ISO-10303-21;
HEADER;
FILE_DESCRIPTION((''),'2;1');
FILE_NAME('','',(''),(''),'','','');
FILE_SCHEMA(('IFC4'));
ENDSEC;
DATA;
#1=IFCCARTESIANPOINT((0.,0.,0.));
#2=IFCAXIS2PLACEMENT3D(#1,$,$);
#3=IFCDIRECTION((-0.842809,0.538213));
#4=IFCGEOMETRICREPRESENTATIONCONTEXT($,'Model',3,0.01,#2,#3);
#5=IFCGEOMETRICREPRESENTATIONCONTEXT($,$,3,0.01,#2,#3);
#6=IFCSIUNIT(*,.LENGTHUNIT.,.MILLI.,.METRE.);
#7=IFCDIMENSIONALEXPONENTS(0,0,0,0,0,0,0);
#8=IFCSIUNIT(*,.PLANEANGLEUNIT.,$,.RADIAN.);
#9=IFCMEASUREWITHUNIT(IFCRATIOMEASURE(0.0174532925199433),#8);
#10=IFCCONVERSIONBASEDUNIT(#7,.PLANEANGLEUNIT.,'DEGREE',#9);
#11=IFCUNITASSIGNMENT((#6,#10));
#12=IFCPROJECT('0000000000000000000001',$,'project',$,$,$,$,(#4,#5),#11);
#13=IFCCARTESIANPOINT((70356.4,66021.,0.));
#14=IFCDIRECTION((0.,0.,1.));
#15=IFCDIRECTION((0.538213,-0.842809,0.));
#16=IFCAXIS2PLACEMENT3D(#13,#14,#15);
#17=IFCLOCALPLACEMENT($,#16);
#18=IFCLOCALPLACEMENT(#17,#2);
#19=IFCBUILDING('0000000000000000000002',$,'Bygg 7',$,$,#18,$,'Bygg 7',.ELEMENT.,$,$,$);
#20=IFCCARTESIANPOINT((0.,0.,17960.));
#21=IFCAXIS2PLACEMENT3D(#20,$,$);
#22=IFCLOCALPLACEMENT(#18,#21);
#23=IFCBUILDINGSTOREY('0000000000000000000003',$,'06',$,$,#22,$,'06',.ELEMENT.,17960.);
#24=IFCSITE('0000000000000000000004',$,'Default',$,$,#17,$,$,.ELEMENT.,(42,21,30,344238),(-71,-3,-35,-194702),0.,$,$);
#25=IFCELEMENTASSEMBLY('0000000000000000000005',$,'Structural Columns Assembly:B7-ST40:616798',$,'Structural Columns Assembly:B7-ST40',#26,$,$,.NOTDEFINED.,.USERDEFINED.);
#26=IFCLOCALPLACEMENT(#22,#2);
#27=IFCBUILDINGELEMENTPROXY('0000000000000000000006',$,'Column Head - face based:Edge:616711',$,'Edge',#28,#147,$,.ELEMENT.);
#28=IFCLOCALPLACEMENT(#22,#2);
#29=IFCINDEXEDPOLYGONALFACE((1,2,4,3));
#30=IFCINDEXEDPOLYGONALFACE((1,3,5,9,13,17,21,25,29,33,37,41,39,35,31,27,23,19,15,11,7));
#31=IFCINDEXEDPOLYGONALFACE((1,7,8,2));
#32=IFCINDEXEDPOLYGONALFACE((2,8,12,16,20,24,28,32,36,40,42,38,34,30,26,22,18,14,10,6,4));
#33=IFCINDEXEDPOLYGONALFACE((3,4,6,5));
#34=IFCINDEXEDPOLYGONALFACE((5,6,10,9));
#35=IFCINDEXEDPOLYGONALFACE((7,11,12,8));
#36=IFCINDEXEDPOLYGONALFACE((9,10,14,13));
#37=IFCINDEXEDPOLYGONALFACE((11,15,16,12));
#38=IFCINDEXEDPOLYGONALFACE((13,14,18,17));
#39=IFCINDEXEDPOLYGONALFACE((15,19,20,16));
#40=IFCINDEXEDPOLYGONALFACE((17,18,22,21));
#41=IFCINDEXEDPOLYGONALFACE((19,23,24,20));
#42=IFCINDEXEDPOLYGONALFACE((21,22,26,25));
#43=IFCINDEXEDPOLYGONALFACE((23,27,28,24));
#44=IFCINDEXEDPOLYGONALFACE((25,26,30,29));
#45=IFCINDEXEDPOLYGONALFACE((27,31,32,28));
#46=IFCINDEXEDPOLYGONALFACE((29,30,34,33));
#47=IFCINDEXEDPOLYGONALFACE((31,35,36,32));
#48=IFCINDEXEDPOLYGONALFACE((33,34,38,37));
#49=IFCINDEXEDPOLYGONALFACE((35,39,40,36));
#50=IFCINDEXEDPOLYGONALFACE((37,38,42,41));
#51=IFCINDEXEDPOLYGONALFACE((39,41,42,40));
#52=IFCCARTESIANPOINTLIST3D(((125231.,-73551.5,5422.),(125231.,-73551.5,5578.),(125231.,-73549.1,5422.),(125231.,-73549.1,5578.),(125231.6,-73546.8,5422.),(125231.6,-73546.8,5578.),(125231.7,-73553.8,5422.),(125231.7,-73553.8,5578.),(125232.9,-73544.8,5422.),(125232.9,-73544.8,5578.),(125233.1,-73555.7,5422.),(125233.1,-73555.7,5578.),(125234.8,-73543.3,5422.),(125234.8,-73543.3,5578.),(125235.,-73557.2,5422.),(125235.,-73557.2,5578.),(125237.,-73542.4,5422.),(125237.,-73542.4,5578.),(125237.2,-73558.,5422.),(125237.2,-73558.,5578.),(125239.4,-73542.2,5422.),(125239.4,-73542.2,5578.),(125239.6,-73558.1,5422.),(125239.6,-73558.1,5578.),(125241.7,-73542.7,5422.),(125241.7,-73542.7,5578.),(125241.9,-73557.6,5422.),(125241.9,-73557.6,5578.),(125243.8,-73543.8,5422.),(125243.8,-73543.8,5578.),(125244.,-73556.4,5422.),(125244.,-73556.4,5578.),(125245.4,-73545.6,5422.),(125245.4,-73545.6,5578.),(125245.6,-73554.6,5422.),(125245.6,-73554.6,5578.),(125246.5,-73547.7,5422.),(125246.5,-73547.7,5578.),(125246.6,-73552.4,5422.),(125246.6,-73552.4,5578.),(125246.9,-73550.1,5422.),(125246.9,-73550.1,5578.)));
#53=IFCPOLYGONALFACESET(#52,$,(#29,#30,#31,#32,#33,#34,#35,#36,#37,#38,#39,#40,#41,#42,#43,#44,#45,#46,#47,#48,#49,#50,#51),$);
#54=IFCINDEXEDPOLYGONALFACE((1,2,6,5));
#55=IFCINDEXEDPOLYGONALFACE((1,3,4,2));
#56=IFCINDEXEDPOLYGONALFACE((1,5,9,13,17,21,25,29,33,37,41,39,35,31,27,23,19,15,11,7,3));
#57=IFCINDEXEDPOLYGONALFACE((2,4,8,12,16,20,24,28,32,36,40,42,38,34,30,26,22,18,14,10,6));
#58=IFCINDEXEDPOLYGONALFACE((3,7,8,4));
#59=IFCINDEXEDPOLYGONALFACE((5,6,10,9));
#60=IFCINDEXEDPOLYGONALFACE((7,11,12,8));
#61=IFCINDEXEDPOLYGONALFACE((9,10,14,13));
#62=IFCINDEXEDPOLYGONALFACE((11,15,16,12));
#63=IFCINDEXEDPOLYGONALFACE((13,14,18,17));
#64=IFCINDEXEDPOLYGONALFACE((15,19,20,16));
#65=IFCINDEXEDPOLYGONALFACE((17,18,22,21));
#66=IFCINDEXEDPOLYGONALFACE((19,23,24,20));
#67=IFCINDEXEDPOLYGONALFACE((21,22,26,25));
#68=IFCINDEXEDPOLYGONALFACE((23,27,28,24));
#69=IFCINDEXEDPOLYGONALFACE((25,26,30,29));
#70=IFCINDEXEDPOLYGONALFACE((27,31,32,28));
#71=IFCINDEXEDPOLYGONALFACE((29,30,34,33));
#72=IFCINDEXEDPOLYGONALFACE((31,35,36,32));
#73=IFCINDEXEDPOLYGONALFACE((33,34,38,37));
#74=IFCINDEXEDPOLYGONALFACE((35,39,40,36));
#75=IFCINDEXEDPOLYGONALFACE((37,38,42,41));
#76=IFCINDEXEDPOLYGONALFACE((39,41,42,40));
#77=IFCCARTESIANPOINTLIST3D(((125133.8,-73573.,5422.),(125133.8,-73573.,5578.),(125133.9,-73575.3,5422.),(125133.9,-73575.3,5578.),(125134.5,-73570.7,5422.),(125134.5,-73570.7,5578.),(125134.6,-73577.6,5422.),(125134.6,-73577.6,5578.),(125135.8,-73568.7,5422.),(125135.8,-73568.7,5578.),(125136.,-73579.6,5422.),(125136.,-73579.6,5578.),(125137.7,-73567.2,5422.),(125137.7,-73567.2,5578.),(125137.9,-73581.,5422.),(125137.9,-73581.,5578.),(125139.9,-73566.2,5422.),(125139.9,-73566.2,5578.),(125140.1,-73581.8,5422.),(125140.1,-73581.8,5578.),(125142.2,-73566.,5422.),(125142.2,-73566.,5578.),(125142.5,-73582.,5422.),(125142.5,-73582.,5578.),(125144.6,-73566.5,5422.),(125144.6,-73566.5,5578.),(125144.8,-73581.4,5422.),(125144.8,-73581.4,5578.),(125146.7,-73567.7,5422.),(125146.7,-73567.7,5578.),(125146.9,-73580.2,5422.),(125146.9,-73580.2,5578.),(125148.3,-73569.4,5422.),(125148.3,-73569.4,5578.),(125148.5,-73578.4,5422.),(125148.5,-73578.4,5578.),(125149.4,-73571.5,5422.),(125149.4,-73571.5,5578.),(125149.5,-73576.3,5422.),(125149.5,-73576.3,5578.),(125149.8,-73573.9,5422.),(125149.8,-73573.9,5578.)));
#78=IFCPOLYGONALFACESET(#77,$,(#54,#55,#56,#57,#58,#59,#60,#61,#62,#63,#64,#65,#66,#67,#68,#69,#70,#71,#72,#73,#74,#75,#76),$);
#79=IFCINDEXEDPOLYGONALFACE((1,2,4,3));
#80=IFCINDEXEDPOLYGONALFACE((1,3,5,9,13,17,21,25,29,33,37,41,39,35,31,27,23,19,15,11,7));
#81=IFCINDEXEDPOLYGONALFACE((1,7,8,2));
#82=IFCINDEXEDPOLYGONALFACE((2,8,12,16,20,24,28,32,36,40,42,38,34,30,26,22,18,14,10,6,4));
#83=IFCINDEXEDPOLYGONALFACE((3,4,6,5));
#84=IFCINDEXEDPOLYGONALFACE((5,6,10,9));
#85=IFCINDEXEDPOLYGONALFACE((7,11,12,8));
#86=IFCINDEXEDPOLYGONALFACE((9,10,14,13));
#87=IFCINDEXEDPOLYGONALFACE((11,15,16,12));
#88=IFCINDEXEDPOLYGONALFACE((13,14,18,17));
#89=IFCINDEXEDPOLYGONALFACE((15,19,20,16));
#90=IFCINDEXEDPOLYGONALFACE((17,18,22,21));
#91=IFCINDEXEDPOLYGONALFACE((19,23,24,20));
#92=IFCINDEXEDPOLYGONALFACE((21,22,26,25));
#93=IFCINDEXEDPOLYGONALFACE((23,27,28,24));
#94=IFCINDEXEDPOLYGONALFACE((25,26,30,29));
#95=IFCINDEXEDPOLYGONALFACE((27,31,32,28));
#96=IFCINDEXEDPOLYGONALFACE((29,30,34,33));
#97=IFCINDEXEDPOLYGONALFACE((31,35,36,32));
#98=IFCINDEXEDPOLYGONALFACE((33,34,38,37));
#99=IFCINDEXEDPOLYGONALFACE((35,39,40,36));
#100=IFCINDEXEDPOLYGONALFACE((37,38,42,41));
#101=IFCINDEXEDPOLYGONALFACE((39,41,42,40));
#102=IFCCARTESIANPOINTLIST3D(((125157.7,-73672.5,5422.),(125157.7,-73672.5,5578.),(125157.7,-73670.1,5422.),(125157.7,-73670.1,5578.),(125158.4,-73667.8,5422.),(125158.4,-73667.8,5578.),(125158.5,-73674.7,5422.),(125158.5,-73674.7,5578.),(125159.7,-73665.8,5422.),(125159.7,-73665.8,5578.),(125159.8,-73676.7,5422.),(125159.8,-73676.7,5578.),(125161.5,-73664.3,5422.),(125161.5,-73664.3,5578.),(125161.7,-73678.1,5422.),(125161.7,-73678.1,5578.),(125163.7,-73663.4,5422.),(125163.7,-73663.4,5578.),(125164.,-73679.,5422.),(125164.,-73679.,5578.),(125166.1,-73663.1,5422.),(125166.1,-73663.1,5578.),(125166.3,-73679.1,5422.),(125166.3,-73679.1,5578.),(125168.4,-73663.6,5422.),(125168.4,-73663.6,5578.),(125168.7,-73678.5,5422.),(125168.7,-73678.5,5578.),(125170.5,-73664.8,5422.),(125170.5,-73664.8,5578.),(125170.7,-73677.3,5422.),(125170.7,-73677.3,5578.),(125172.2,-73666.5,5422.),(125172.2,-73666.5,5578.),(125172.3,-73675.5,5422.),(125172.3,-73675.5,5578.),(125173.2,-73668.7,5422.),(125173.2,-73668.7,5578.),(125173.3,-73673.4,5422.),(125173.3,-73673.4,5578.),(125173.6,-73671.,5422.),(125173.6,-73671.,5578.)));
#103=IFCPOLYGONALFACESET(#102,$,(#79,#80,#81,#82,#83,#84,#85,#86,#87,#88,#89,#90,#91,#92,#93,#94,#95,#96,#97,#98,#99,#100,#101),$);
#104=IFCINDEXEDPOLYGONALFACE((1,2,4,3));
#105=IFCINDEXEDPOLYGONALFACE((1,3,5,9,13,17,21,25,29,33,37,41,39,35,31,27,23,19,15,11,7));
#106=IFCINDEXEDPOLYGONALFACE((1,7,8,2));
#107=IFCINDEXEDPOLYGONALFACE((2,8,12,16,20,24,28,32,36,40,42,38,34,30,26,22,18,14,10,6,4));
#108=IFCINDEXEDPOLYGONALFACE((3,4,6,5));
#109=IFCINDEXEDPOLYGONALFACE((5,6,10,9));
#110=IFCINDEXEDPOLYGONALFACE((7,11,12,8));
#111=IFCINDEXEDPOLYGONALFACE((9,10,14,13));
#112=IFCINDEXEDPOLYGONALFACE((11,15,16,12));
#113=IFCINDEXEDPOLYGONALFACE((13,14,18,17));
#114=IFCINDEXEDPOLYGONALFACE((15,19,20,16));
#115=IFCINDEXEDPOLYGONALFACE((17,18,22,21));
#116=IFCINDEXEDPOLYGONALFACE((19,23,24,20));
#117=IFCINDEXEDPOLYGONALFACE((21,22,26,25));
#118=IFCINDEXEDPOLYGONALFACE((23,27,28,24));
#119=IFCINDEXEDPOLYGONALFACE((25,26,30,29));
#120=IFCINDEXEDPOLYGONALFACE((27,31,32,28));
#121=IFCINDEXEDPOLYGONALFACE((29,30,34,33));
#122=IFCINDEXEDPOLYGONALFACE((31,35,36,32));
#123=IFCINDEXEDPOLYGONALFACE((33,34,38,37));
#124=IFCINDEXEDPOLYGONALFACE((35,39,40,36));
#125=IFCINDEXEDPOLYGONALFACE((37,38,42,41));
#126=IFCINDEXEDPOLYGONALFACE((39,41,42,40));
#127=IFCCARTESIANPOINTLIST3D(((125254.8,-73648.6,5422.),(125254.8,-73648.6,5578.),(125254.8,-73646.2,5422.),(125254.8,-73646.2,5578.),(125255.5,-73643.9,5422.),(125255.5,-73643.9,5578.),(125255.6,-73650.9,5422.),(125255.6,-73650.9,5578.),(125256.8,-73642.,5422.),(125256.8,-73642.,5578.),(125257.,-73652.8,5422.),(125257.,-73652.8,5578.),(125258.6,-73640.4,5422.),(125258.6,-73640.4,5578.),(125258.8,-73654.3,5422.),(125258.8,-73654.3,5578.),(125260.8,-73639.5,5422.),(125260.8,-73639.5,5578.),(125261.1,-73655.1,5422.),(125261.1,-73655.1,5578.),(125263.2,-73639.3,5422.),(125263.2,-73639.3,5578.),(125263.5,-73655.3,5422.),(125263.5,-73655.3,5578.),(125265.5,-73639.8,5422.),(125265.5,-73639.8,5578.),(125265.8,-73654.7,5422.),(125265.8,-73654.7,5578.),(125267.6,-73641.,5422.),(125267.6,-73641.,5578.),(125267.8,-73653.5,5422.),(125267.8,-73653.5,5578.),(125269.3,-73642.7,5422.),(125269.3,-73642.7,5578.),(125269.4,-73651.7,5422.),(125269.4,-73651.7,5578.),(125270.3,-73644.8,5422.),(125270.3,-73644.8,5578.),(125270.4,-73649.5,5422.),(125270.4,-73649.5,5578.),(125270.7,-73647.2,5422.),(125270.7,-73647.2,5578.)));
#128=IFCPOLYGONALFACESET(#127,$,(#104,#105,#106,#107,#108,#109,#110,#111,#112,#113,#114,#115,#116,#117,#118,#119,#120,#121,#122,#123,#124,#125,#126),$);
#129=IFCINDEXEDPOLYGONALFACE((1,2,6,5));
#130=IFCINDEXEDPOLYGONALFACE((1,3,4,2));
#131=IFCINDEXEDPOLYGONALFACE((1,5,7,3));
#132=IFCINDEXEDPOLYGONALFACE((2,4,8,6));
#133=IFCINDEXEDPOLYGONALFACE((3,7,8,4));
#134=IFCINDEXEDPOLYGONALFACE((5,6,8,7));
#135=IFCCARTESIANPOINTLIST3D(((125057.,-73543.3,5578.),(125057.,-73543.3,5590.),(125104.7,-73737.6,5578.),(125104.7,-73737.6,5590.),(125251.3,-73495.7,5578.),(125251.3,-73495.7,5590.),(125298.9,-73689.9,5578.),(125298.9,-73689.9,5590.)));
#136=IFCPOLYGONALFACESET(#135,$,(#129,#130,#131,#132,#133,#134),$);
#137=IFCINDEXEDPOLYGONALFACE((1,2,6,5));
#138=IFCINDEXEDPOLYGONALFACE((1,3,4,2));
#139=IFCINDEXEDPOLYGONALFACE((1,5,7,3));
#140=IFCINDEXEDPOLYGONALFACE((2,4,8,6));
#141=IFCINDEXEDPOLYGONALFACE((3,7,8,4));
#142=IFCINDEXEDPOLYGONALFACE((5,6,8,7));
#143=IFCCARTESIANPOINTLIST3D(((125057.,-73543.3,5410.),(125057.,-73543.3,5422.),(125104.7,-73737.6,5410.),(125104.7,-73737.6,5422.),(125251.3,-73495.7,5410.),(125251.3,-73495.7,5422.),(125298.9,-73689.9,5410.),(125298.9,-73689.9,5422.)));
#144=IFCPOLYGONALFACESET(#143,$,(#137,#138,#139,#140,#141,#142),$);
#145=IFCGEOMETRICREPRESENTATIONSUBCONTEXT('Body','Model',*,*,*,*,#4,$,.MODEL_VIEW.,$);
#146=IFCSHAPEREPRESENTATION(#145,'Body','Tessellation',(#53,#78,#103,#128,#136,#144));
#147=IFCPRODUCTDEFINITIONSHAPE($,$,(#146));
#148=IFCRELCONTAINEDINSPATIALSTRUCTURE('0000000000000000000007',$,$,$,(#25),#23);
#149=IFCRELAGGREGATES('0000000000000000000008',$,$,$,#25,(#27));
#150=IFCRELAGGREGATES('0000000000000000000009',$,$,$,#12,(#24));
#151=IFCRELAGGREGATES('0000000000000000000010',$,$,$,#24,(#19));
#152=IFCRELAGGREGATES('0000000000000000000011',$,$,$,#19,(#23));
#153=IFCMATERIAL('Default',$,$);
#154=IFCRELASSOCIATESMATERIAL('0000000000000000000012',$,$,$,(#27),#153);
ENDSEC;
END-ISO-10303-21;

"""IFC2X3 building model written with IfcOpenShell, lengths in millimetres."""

from ifc_helpers import new_model, entity, si_unit, converted_unit, direction, frame, frame_2d, origin, origin_2d_with_axis, place, context, subcontext, project, spatial, rectangle, circle, extrude, source, transform, mapped, material, element, aggregate, save


model = new_model("IFC2X3")

# Units and contexts
model_context = context("Model", 3, precision=0.01, world=origin(), true_north=direction((-0.842809, 0.538213)))
context_of_model = context(None, 3, precision=0.01, world=origin(), true_north=direction((-0.842809, 0.538213)))
body_context = subcontext(model_context, "Body", "Model", "MODEL_VIEW")
ifc_project = project(units=[si_unit("LENGTHUNIT", "METRE", prefix="MILLI"), converted_unit("PLANEANGLEUNIT", "DEGREE", entity("IfcRatioMeasure", 0.0174532925199433), si_unit("PLANEANGLEUNIT", "RADIAN"), dimensions=[0, 0, 0, 0, 0, 0, 0])], contexts=[model_context, context_of_model])

# Site, building, storey
site_placement = place(None, frame((70356.4, 66021.0, 0.0), z_axis=(0.0, 0.0, 1.0), x_axis=(0.538213, -0.842809, 0.0)))
site = spatial("IfcSite", under=ifc_project, at=site_placement, Name="Default", CompositionType="ELEMENT", RefLatitude=(42, 21, 30, 344238), RefLongitude=(-71, -3, -35, -194702), RefElevation=0.0)
building_placement = place(site_placement, origin())
building = spatial("IfcBuilding", under=site, at=building_placement, Name="Bygg 7", LongName="Bygg 7", CompositionType="ELEMENT")
storey_placement = place(building_placement, frame((0.0, 0.0, 17960.0)))
storey = spatial("IfcBuildingStorey", under=building, at=storey_placement, Name="06", LongName="06", CompositionType="ELEMENT", Elevation=17960.0)

# Element assembly
assembly_1_placement = place(storey_placement, origin())
assembly_1 = element("IfcElementAssembly", 1, at=assembly_1_placement, inside=storey, Name="Structural Columns Assembly:B7-ST40:616798", ObjectType="Structural Columns Assembly:B7-ST40", AssemblyPlace="NOTDEFINED", PredefinedType="USERDEFINED")

# Building element proxy
ifc_material_1 = material(Name="Default")
shared_shape_1 = source(origin(), body_context, "Body", "SweptSolid", [
    extrude(circle(Radius=8.0, at=frame_2d((0.0, 0.0), x_axis=(1.0, 0.0))), frame((50.0, -135.0, 12.0)), (0.0, 0.0, 1.0), 156.0),
    extrude(circle(Radius=8.0, at=frame_2d((0.0, 0.0), x_axis=(1.0, 0.0))), frame((50.0, -35.0, 12.0)), (0.0, 0.0, 1.0), 156.0),
    extrude(circle(Radius=8.0, at=frame_2d((0.0, 0.0), x_axis=(1.0, 0.0))), frame((-50.0, -35.0, 12.0)), (0.0, 0.0, 1.0), 156.0),
    extrude(circle(Radius=8.0, at=frame_2d((0.0, 0.0), x_axis=(1.0, 0.0))), frame((-50.0, -135.0, 12.0)), (0.0, 0.0, 1.0), 156.0),
    extrude(rectangle(XDim=200.0, YDim=200.0, at=origin_2d_with_axis()), frame((0.0, -60.0, 168.0), z_axis=(0.0, 0.0, 1.0), x_axis=(-1.0, 0.0, 0.0)), (0.0, 0.0, 1.0), 12.0),
    extrude(rectangle(XDim=200.0, YDim=200.0, at=origin_2d_with_axis()), frame((0.0, -60.0, 0.0), z_axis=(0.0, 0.0, 1.0), x_axis=(0.0, 1.0, 0.0)), (0.0, 0.0, 1.0), 12.0),
])
proxy_1_placement = place(assembly_1_placement, frame((125119.7, -73630.9, 5410.0), z_axis=(0.0, 0.0, 1.0), x_axis=(-0.238381, 0.971172, 0.0)))
proxy_1 = element("IfcBuildingElementProxy", 2, at=proxy_1_placement, material=ifc_material_1, Name="Column Head - face based:Edge:616711", ObjectType="Edge", CompositionType="ELEMENT", context=body_context, shape_type="MappedRepresentation", body=[
    mapped(shared_shape_1, transform((0.0, 0.0, 0.0), scale=1.0)),
])
aggregate(assembly_1, [proxy_1])

save(model, "model.ifc")
